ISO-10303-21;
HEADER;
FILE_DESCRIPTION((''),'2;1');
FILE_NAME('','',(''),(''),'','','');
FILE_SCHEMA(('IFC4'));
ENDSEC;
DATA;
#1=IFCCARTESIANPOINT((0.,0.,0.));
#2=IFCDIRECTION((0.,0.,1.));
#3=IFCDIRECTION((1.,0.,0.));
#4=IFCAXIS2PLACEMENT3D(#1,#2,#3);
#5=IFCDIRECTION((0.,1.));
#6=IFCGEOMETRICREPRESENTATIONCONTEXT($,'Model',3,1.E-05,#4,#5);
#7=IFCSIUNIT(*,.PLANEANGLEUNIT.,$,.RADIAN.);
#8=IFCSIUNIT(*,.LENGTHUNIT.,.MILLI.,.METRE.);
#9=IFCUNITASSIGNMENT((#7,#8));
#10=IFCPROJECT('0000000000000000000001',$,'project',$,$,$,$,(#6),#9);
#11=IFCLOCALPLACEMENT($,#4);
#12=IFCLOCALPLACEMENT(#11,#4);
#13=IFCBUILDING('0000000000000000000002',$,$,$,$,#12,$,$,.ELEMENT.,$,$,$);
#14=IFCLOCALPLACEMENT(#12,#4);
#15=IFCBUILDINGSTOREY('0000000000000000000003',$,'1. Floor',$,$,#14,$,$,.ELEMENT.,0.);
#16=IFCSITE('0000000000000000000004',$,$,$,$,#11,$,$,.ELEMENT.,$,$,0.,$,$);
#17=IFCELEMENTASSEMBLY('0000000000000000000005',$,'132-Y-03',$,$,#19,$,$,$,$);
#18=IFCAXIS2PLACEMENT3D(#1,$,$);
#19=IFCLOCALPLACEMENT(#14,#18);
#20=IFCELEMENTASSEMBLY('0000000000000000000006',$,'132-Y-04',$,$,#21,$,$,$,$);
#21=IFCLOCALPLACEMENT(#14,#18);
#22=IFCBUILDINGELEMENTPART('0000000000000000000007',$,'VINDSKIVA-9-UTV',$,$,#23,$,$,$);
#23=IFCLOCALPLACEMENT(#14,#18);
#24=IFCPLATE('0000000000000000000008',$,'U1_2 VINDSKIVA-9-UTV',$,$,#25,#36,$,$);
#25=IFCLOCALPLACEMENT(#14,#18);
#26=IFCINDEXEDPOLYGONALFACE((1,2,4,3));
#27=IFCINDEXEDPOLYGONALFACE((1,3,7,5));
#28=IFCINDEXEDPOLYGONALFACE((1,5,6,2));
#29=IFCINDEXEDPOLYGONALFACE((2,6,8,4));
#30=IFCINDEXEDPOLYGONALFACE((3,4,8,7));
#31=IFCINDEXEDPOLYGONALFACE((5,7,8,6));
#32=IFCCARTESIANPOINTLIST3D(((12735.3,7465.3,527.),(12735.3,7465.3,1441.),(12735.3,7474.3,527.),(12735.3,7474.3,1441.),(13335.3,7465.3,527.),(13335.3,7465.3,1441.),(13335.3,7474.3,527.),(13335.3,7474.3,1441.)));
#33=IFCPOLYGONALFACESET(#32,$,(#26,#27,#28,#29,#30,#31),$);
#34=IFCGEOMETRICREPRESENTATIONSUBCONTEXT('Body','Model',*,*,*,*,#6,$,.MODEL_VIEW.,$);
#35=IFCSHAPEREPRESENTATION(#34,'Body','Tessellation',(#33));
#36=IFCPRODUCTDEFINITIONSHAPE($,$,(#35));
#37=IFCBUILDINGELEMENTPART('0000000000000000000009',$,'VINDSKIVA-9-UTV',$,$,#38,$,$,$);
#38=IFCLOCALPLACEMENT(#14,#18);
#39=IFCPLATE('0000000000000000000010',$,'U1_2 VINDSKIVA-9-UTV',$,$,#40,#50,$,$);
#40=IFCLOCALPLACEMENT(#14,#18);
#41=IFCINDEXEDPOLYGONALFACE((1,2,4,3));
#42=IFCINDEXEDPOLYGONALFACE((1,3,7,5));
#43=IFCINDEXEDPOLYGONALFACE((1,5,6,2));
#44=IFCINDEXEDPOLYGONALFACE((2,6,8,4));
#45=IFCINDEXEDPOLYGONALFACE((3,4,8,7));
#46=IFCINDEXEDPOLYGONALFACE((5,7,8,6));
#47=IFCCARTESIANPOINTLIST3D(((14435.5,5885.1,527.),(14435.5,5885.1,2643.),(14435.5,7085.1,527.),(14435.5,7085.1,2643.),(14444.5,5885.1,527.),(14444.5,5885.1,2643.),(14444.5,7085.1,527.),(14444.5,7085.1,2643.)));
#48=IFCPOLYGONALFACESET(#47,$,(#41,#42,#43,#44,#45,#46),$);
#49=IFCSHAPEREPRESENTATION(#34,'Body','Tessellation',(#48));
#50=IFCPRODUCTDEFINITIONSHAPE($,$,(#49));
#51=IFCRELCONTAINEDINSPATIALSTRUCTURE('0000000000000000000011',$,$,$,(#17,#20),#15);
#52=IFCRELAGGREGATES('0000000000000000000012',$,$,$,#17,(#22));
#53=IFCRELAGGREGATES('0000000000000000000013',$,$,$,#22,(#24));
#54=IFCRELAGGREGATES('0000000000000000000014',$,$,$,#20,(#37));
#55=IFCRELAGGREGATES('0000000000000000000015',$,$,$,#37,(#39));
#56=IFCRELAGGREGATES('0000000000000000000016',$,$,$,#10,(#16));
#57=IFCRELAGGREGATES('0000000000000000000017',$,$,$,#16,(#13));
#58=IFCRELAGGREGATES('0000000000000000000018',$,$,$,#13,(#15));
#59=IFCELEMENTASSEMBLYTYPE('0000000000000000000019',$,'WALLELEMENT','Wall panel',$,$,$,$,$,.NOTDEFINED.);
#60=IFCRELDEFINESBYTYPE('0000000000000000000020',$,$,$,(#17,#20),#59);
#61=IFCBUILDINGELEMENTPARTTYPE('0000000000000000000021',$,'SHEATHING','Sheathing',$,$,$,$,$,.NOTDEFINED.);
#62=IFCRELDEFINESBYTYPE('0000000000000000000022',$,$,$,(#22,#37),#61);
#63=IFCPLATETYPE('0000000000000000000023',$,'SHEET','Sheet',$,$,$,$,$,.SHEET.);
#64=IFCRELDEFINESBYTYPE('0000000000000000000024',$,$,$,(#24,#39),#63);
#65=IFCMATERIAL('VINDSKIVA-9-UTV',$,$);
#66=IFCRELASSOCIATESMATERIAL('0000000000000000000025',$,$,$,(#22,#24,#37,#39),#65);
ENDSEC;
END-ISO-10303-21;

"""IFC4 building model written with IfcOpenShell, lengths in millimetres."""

from ifc_helpers import new_model, si_unit, direction, frame, origin_with_axes, origin_2d_with_axis, place, context, subcontext, project, spatial, rectangle, extrude, material, type_object, element, aggregate, save


model = new_model("IFC4")

# Units and contexts
model_context = context("Model", 3, precision=1e-05, world=origin_with_axes(), true_north=direction((0.0, 1.0)))
body_context = subcontext(model_context, "Body", "Model", "MODEL_VIEW")
ifc_project = project(units=[si_unit("PLANEANGLEUNIT", "RADIAN"), si_unit("LENGTHUNIT", "METRE", prefix="MILLI")], contexts=[model_context])

# Site, building, storey
site_placement = place(None, origin_with_axes())
site = spatial("IfcSite", under=ifc_project, at=site_placement, CompositionType="ELEMENT", RefElevation=0.0)
building_placement = place(site_placement, origin_with_axes())
building = spatial("IfcBuilding", under=site, at=building_placement, CompositionType="ELEMENT")
storey_placement = place(building_placement, origin_with_axes())
storey = spatial("IfcBuildingStorey", under=building, at=storey_placement, Name="1. Floor", CompositionType="ELEMENT", Elevation=0.0)

# Element assembly
element_assembly_type_1 = type_object("IfcElementAssemblyType", Name="WALLELEMENT", Description="Wall panel", PredefinedType="NOTDEFINED")
assembly_1_placement = place(storey_placement, origin_with_axes())
assembly_1 = element("IfcElementAssembly", 1, at=assembly_1_placement, inside=storey, type_object=element_assembly_type_1, Name="132-Y-03")

# Element assembly
assembly_2_placement = place(storey_placement, origin_with_axes())
assembly_2 = element("IfcElementAssembly", 2, at=assembly_2_placement, inside=storey, type_object=element_assembly_type_1, Name="132-Y-04")

# Building element part
ifc_material_1 = material(Name="VINDSKIVA-9-UTV")
building_element_part_type_1 = type_object("IfcBuildingElementPartType", Name="SHEATHING", Description="Sheathing", PredefinedType="NOTDEFINED")
building_element_part_1_placement = place(storey_placement, origin_with_axes())
building_element_part_1 = element("IfcBuildingElementPart", 3, at=building_element_part_1_placement, type_object=building_element_part_type_1, material=ifc_material_1, Name="VINDSKIVA-9-UTV")
aggregate(assembly_1, [building_element_part_1])

# Plate
plate_type_1 = type_object("IfcPlateType", Name="SHEET", Description="Sheet", PredefinedType="SHEET")
plate_1_placement = place(storey_placement, frame((13335.3, 7474.3, 2527.0), z_axis=(0.0, 1.0, 0.0), x_axis=(1.0, 0.0, 0.0)))
plate_1 = element("IfcPlate", 4, at=plate_1_placement, type_object=plate_type_1, material=ifc_material_1, Name="U1_2 VINDSKIVA-9-UTV", context=body_context, shape_type="SweptSolid", body=[
    extrude(rectangle(XDim=9.0, YDim=600.0, at=origin_2d_with_axis()), frame((-300.0, 1086.0, -4.5), z_axis=(0.0, 1.0, 0.0), x_axis=(0.0, 0.0, 1.0)), (0.0, 0.0, 1.0), 914.0),
])
aggregate(building_element_part_1, [plate_1])

# Building element part
building_element_part_2_placement = place(storey_placement, origin_with_axes())
building_element_part_2 = element("IfcBuildingElementPart", 5, at=building_element_part_2_placement, type_object=building_element_part_type_1, material=ifc_material_1, Name="VINDSKIVA-9-UTV")
aggregate(assembly_2, [building_element_part_2])

# Plate
plate_2_placement = place(storey_placement, frame((14444.5, 6485.1, 2527.0), z_axis=(1.0, 0.0, 0.0), x_axis=(0.0, -1.0, 0.0)))
plate_2 = element("IfcPlate", 6, at=plate_2_placement, type_object=plate_type_1, material=ifc_material_1, Name="U1_2 VINDSKIVA-9-UTV", context=body_context, shape_type="SweptSolid", body=[
    extrude(rectangle(XDim=9.0, YDim=1200.0, at=origin_2d_with_axis()), frame((0.0, -116.0, -4.5), z_axis=(0.0, 1.0, 0.0), x_axis=(0.0, 0.0, 1.0)), (0.0, 0.0, 1.0), 2116.0),
])
aggregate(building_element_part_2, [plate_2])

save(model, "model.ifc")
